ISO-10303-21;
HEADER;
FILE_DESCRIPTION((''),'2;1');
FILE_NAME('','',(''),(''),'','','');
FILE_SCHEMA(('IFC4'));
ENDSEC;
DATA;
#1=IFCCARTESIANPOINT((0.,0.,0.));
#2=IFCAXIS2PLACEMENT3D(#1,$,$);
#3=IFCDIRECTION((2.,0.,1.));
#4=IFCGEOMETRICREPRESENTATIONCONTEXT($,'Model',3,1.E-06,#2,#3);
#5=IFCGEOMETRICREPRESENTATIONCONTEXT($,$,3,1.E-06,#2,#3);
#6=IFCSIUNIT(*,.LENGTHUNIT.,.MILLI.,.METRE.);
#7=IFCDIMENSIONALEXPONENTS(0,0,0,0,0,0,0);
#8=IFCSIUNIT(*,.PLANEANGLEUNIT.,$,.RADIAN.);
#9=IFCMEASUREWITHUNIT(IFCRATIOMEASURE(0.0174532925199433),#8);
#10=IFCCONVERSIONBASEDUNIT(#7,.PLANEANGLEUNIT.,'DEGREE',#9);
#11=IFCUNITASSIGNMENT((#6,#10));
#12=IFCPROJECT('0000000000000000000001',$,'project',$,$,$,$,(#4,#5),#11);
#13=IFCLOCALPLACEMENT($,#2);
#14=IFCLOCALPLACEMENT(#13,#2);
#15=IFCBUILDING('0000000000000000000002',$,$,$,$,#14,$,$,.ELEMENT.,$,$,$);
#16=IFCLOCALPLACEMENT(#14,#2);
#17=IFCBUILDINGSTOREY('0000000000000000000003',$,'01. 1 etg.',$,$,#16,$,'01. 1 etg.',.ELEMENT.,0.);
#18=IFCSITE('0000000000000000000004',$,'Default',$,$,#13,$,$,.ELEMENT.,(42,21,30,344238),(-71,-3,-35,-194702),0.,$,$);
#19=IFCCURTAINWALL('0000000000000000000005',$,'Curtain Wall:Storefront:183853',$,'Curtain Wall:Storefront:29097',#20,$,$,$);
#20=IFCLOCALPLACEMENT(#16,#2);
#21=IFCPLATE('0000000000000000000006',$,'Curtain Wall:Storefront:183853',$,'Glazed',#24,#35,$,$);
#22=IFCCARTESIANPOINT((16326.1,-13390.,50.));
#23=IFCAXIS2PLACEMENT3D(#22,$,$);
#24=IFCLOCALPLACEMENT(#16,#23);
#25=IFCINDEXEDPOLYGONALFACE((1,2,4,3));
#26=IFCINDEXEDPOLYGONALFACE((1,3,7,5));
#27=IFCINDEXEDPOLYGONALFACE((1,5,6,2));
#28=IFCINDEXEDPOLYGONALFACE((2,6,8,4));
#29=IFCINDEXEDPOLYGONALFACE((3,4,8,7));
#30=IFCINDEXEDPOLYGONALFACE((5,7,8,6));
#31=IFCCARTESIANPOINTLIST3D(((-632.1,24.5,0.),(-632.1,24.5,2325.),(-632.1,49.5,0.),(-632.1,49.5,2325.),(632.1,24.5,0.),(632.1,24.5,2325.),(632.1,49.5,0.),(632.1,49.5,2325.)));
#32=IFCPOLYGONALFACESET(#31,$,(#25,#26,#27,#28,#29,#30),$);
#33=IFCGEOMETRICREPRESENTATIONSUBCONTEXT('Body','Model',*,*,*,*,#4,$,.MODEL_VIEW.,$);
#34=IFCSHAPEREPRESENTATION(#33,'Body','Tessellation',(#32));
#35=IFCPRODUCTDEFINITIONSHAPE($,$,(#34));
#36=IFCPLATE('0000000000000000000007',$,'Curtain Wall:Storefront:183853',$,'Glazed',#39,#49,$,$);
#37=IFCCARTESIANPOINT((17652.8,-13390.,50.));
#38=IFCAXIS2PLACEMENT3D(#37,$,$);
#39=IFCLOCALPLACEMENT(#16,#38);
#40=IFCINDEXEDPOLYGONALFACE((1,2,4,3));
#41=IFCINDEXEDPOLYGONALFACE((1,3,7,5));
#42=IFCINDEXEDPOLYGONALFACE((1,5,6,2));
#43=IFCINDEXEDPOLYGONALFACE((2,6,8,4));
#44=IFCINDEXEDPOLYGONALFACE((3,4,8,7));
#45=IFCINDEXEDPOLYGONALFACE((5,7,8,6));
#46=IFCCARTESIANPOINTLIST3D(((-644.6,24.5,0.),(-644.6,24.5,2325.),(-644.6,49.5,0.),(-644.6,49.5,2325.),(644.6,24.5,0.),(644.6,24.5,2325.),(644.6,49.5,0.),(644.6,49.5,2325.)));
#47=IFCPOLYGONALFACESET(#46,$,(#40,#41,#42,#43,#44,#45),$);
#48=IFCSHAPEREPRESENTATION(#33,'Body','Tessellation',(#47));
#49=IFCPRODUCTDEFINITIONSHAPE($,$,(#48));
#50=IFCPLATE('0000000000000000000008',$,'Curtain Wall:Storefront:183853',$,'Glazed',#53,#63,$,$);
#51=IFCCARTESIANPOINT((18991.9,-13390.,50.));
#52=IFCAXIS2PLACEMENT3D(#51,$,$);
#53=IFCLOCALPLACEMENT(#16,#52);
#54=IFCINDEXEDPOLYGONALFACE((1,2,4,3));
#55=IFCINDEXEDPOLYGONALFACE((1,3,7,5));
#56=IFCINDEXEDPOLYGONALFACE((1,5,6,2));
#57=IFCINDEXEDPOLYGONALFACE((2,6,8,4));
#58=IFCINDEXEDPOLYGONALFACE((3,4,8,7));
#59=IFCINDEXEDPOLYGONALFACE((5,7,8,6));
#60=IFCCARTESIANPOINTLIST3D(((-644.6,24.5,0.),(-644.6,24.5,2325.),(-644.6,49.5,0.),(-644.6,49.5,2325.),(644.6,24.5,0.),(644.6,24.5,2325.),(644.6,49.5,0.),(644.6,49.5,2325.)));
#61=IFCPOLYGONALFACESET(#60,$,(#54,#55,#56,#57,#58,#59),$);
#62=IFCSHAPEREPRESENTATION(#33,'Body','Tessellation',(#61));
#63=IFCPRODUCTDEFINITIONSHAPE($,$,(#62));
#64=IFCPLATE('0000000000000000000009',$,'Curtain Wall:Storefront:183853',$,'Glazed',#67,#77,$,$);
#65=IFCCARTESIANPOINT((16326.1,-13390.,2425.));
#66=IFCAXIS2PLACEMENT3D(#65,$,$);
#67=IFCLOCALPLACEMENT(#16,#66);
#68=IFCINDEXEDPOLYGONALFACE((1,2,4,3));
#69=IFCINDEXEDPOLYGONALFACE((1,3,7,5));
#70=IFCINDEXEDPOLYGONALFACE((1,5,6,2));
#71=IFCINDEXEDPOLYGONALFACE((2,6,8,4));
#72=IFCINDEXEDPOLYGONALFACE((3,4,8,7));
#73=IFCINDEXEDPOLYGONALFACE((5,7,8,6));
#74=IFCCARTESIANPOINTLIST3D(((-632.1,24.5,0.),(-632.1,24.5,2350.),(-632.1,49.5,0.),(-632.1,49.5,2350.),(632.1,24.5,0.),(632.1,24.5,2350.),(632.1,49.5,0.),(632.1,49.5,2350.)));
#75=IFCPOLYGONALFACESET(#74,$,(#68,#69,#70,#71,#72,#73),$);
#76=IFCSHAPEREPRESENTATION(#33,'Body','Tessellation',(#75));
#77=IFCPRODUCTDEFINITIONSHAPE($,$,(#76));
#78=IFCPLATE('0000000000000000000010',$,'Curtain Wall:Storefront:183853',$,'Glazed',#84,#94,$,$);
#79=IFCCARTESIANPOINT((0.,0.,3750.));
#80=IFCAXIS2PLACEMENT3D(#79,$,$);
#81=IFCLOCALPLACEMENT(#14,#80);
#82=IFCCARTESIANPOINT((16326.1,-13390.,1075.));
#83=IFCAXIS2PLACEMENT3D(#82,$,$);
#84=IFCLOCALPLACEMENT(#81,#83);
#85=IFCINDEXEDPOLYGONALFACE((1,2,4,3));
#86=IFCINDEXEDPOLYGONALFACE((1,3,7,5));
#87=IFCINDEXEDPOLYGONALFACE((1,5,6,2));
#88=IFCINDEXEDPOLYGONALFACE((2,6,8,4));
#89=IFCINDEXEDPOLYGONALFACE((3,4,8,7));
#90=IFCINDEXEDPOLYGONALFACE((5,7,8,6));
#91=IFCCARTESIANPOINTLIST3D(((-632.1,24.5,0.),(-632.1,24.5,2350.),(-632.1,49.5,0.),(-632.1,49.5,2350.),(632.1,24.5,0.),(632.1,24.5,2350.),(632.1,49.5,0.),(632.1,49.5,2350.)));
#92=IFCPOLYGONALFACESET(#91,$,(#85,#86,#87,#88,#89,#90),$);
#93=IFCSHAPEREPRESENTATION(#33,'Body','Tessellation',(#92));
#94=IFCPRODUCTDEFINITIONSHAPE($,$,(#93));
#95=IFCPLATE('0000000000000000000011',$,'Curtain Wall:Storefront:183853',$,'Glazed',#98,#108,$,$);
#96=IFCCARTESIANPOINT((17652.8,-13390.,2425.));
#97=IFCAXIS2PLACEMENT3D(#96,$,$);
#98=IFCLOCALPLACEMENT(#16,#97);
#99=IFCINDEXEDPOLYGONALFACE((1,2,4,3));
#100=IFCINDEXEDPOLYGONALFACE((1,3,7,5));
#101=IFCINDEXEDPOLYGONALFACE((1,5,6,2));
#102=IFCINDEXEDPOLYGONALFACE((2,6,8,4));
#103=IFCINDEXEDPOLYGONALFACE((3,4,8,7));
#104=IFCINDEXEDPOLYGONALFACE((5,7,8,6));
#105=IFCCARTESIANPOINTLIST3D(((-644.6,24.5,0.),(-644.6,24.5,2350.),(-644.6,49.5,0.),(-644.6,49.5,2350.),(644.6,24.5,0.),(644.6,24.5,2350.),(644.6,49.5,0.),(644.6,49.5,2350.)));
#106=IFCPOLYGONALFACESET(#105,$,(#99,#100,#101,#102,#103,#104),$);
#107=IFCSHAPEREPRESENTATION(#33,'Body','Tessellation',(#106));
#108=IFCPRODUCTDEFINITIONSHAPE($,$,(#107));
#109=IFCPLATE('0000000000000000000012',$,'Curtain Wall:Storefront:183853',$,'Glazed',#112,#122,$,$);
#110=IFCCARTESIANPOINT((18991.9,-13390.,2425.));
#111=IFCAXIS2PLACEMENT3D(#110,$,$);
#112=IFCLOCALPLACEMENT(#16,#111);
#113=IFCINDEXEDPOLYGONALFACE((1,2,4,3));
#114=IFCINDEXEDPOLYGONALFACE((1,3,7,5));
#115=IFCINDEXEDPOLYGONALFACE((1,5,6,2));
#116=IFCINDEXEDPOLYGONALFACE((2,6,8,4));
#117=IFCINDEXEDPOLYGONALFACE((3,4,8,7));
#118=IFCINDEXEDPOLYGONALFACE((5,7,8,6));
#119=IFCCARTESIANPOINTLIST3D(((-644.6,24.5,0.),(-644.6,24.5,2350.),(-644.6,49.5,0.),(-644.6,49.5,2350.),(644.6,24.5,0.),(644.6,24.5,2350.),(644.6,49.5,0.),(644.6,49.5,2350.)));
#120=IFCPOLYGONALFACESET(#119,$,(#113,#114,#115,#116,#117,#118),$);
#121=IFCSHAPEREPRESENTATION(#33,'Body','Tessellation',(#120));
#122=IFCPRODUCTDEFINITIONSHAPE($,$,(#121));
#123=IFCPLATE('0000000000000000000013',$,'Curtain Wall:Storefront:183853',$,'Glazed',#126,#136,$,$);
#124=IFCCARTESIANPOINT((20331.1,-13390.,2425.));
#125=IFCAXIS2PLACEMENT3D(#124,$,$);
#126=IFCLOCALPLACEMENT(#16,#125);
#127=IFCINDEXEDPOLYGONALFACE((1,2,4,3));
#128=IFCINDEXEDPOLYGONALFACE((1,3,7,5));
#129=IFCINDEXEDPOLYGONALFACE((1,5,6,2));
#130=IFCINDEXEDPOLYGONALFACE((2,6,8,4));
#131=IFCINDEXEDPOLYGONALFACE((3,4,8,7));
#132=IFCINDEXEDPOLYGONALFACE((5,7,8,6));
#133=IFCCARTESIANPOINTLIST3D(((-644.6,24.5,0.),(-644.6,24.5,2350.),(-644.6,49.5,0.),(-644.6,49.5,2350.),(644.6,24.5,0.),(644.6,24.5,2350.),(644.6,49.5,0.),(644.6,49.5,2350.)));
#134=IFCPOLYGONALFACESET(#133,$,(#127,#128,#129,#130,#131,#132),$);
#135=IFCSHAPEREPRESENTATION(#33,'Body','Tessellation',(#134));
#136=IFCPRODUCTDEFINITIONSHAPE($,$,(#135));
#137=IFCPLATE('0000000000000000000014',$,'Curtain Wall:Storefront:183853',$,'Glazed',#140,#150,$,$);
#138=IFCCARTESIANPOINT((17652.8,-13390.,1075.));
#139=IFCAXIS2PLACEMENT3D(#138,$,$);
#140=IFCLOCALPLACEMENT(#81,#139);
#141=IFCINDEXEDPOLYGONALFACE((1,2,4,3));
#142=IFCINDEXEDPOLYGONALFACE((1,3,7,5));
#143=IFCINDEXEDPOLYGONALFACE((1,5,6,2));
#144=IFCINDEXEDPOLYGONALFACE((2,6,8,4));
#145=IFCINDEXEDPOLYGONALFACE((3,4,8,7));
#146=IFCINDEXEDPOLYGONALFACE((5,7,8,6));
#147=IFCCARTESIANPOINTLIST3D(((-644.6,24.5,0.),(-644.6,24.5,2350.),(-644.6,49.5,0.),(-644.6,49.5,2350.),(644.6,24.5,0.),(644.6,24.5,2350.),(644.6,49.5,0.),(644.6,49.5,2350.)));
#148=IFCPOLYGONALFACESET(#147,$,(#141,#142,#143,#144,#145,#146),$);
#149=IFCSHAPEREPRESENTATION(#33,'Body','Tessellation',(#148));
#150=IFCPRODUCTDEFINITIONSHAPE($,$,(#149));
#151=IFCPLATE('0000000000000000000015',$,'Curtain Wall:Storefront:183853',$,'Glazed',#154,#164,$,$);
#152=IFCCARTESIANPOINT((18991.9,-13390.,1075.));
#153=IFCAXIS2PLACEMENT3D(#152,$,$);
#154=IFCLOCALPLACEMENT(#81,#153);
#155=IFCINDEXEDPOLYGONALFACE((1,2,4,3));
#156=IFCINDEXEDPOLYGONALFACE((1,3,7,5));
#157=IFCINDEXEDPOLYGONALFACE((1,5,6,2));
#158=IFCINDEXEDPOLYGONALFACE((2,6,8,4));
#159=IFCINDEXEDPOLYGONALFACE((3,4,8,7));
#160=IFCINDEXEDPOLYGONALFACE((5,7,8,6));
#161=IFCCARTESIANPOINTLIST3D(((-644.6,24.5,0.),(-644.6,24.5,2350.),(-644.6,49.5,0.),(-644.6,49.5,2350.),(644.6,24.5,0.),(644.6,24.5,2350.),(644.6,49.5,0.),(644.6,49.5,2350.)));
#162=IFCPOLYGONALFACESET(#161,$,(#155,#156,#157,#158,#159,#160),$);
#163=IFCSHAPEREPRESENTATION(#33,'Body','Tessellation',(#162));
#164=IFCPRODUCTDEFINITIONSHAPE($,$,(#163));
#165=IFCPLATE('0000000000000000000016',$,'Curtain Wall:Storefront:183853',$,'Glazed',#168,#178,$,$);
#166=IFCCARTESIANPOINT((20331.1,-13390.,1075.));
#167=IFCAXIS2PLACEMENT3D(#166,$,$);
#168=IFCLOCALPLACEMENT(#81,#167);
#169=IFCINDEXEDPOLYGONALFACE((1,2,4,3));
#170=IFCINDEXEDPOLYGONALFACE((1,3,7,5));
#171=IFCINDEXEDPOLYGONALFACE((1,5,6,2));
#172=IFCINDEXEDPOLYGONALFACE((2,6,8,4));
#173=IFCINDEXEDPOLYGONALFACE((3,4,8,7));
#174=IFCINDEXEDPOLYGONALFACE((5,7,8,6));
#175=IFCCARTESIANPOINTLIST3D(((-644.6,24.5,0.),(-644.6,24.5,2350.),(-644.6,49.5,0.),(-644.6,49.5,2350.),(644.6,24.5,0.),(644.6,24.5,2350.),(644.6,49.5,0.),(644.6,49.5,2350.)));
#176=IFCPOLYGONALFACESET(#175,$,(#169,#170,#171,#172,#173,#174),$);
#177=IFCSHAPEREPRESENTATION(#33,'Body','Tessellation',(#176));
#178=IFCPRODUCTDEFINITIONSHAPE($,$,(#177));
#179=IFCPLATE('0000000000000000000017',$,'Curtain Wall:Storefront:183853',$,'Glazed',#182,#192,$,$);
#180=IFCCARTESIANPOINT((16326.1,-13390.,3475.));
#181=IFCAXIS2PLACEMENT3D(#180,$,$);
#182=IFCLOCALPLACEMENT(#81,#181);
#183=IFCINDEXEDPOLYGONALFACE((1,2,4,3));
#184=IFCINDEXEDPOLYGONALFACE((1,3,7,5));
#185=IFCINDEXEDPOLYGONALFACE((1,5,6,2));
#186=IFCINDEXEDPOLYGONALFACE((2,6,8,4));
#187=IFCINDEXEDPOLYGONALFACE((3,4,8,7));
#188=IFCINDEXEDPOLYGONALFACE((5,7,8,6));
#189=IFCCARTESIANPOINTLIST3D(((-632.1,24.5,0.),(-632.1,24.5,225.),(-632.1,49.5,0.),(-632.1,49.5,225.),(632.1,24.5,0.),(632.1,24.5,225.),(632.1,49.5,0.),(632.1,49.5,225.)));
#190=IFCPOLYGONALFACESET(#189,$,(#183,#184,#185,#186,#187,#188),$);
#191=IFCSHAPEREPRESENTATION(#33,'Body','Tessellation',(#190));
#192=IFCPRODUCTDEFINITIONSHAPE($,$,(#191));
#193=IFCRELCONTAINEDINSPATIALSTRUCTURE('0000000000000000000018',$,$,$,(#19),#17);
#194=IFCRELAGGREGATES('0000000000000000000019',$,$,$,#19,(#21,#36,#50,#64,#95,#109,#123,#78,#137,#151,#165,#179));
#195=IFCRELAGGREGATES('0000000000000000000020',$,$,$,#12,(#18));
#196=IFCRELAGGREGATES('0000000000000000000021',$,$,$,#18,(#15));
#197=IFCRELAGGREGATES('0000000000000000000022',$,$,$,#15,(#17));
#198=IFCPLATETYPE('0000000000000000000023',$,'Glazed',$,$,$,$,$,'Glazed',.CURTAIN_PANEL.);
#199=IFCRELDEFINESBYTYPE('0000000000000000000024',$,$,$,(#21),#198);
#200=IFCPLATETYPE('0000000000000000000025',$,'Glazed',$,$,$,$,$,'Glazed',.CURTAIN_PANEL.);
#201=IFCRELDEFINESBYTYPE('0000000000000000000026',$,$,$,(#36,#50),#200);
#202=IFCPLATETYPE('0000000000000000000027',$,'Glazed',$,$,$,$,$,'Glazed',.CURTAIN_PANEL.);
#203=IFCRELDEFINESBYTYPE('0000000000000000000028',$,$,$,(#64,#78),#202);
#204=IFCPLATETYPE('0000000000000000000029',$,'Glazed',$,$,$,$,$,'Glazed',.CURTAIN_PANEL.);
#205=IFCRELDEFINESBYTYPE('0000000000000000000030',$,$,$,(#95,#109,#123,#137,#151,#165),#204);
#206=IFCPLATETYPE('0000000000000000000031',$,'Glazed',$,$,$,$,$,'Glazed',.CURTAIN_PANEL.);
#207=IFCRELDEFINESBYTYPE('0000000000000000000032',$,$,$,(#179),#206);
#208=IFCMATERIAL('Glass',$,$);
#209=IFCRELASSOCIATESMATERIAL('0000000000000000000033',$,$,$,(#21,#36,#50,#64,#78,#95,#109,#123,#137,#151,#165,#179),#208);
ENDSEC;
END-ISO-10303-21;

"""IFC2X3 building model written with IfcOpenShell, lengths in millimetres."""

from ifc_helpers import new_model, entity, si_unit, converted_unit, direction, frame, origin, origin_2d_with_axis, place, context, subcontext, project, spatial, rectangle, extrude, source, transform, mapped, material, type_object, type_shapes, element, aggregate, save


model = new_model("IFC2X3")

# Units and contexts
model_context = context("Model", 3, precision=1e-06, world=origin(), true_north=direction((2.0, 0.0, 1.0)))
context_of_model = context(None, 3, precision=1e-06, world=origin(), true_north=direction((2.0, 0.0, 1.0)))
body_context = subcontext(model_context, "Body", "Model", "MODEL_VIEW")
ifc_project = project(units=[si_unit("LENGTHUNIT", "METRE", prefix="MILLI"), converted_unit("PLANEANGLEUNIT", "DEGREE", entity("IfcRatioMeasure", 0.0174532925199433), si_unit("PLANEANGLEUNIT", "RADIAN"), dimensions=[0, 0, 0, 0, 0, 0, 0])], contexts=[model_context, context_of_model])

# Site, building, storey
site_placement = place(None, origin())
site = spatial("IfcSite", under=ifc_project, at=site_placement, Name="Default", CompositionType="ELEMENT", RefLatitude=(42, 21, 30, 344238), RefLongitude=(-71, -3, -35, -194702), RefElevation=0.0)
building_placement = place(site_placement, origin())
building = spatial("IfcBuilding", under=site, at=building_placement, CompositionType="ELEMENT")
storey_placement = place(building_placement, origin())
storey = spatial("IfcBuildingStorey", under=building, at=storey_placement, Name="01. 1 etg.", LongName="01. 1 etg.", CompositionType="ELEMENT", Elevation=0.0)

# Curtain wall, plates
curtain_wall_placement = place(storey_placement, origin())
curtain_wall = element("IfcCurtainWall", 1, at=curtain_wall_placement, inside=storey, Name="Curtain Wall:Storefront:183853", ObjectType="Curtain Wall:Storefront:29097")
ifc_material_1 = material(Name="Glass")
plate_type_1 = type_object("IfcPlateType", Name="Glazed", ElementType="Glazed", PredefinedType="CURTAIN_PANEL")
shared_shape_1 = source(origin(), body_context, "Body", "SweptSolid", [
    extrude(rectangle(XDim=25.0, YDim=1264.2, at=origin_2d_with_axis()), frame((0.0, 37.0, 0.0), z_axis=(0.0, 0.0, 1.0), x_axis=(0.0, 1.0, 0.0)), (0.0, 0.0, 1.0), 2325.0),
])
type_shapes(plate_type_1, [shared_shape_1])
plate_1_placement = place(storey_placement, frame((16326.1, -13390.0, 50.0)))
plate_1 = element("IfcPlate", 2, at=plate_1_placement, type_object=plate_type_1, material=ifc_material_1, Name="Curtain Wall:Storefront:183853", ObjectType="Glazed", context=body_context, shape_type="MappedRepresentation", body=[
    mapped(shared_shape_1, transform((0.0, 0.0, 0.0), scale=1.0)),
])
plate_type_2 = type_object("IfcPlateType", Name="Glazed", ElementType="Glazed", PredefinedType="CURTAIN_PANEL")
shared_shape_2 = source(origin(), body_context, "Body", "SweptSolid", [
    extrude(rectangle(XDim=25.0, YDim=1289.2, at=origin_2d_with_axis()), frame((0.0, 37.0, 0.0), z_axis=(0.0, 0.0, 1.0), x_axis=(0.0, 1.0, 0.0)), (0.0, 0.0, 1.0), 2325.0),
])
type_shapes(plate_type_2, [shared_shape_2])
plate_2_placement = place(storey_placement, frame((17652.8, -13390.0, 50.0)))
plate_2 = element("IfcPlate", 3, at=plate_2_placement, type_object=plate_type_2, material=ifc_material_1, Name="Curtain Wall:Storefront:183853", ObjectType="Glazed", context=body_context, shape_type="MappedRepresentation", body=[
    mapped(shared_shape_2, transform((0.0, 0.0, 0.0), scale=1.0)),
])
plate_3_placement = place(storey_placement, frame((18991.9, -13390.0, 50.0)))
plate_3 = element("IfcPlate", 4, at=plate_3_placement, type_object=plate_type_2, material=ifc_material_1, Name="Curtain Wall:Storefront:183853", ObjectType="Glazed", context=body_context, shape_type="MappedRepresentation", body=[
    mapped(shared_shape_2, transform((0.0, 0.0, 0.0), scale=1.0)),
])
plate_type_3 = type_object("IfcPlateType", Name="Glazed", ElementType="Glazed", PredefinedType="CURTAIN_PANEL")
shared_shape_3 = source(origin(), body_context, "Body", "SweptSolid", [
    extrude(rectangle(XDim=25.0, YDim=1264.2, at=origin_2d_with_axis()), frame((0.0, 37.0, 0.0), z_axis=(0.0, 0.0, 1.0), x_axis=(0.0, 1.0, 0.0)), (0.0, 0.0, 1.0), 2350.0),
])
type_shapes(plate_type_3, [shared_shape_3])
plate_4_placement = place(storey_placement, frame((16326.1, -13390.0, 2425.0)))
plate_4 = element("IfcPlate", 5, at=plate_4_placement, type_object=plate_type_3, material=ifc_material_1, Name="Curtain Wall:Storefront:183853", ObjectType="Glazed", context=body_context, shape_type="MappedRepresentation", body=[
    mapped(shared_shape_3, transform((0.0, 0.0, 0.0), scale=1.0)),
])
placement = place(building_placement, frame((0.0, 0.0, 3750.0)))
plate_5_placement = place(placement, frame((16326.1, -13390.0, 1075.0)))
plate_5 = element("IfcPlate", 6, at=plate_5_placement, type_object=plate_type_3, material=ifc_material_1, Name="Curtain Wall:Storefront:183853", ObjectType="Glazed", context=body_context, shape_type="MappedRepresentation", body=[
    mapped(shared_shape_3, transform((0.0, 0.0, 0.0), scale=1.0)),
])
plate_type_4 = type_object("IfcPlateType", Name="Glazed", ElementType="Glazed", PredefinedType="CURTAIN_PANEL")
shared_shape_4 = source(origin(), body_context, "Body", "SweptSolid", [
    extrude(rectangle(XDim=25.0, YDim=1289.2, at=origin_2d_with_axis()), frame((0.0, 37.0, 0.0), z_axis=(0.0, 0.0, 1.0), x_axis=(0.0, 1.0, 0.0)), (0.0, 0.0, 1.0), 2350.0),
])
type_shapes(plate_type_4, [shared_shape_4])
plate_6_placement = place(storey_placement, frame((17652.8, -13390.0, 2425.0)))
plate_6 = element("IfcPlate", 7, at=plate_6_placement, type_object=plate_type_4, material=ifc_material_1, Name="Curtain Wall:Storefront:183853", ObjectType="Glazed", context=body_context, shape_type="MappedRepresentation", body=[
    mapped(shared_shape_4, transform((0.0, 0.0, 0.0), scale=1.0)),
])
plate_7_placement = place(storey_placement, frame((18991.9, -13390.0, 2425.0)))
plate_7 = element("IfcPlate", 8, at=plate_7_placement, type_object=plate_type_4, material=ifc_material_1, Name="Curtain Wall:Storefront:183853", ObjectType="Glazed", context=body_context, shape_type="MappedRepresentation", body=[
    mapped(shared_shape_4, transform((0.0, 0.0, 0.0), scale=1.0)),
])
plate_8_placement = place(storey_placement, frame((20331.1, -13390.0, 2425.0)))
plate_8 = element("IfcPlate", 9, at=plate_8_placement, type_object=plate_type_4, material=ifc_material_1, Name="Curtain Wall:Storefront:183853", ObjectType="Glazed", context=body_context, shape_type="MappedRepresentation", body=[
    mapped(shared_shape_4, transform((0.0, 0.0, 0.0), scale=1.0)),
])
plate_9_placement = place(placement, frame((17652.8, -13390.0, 1075.0)))
plate_9 = element("IfcPlate", 10, at=plate_9_placement, type_object=plate_type_4, material=ifc_material_1, Name="Curtain Wall:Storefront:183853", ObjectType="Glazed", context=body_context, shape_type="MappedRepresentation", body=[
    mapped(shared_shape_4, transform((0.0, 0.0, 0.0), scale=1.0)),
])
plate_10_placement = place(placement, frame((18991.9, -13390.0, 1075.0)))
plate_10 = element("IfcPlate", 11, at=plate_10_placement, type_object=plate_type_4, material=ifc_material_1, Name="Curtain Wall:Storefront:183853", ObjectType="Glazed", context=body_context, shape_type="MappedRepresentation", body=[
    mapped(shared_shape_4, transform((0.0, 0.0, 0.0), scale=1.0)),
])
plate_11_placement = place(placement, frame((20331.1, -13390.0, 1075.0)))
plate_11 = element("IfcPlate", 12, at=plate_11_placement, type_object=plate_type_4, material=ifc_material_1, Name="Curtain Wall:Storefront:183853", ObjectType="Glazed", context=body_context, shape_type="MappedRepresentation", body=[
    mapped(shared_shape_4, transform((0.0, 0.0, 0.0), scale=1.0)),
])
plate_type_5 = type_object("IfcPlateType", Name="Glazed", ElementType="Glazed", PredefinedType="CURTAIN_PANEL")
shared_shape_5 = source(origin(), body_context, "Body", "SweptSolid", [
    extrude(rectangle(XDim=25.0, YDim=1264.2, at=origin_2d_with_axis()), frame((0.0, 37.0, 0.0), z_axis=(0.0, 0.0, 1.0), x_axis=(0.0, 1.0, 0.0)), (0.0, 0.0, 1.0), 225.0),
])
type_shapes(plate_type_5, [shared_shape_5])
plate_12_placement = place(placement, frame((16326.1, -13390.0, 3475.0)))
plate_12 = element("IfcPlate", 13, at=plate_12_placement, type_object=plate_type_5, material=ifc_material_1, Name="Curtain Wall:Storefront:183853", ObjectType="Glazed", context=body_context, shape_type="MappedRepresentation", body=[
    mapped(shared_shape_5, transform((0.0, 0.0, 0.0), scale=1.0)),
])

aggregate(curtain_wall, [plate_1, plate_2, plate_3, plate_4, plate_6, plate_7, plate_8, plate_5, plate_9, plate_10, plate_11, plate_12])

save(model, "model.ifc")
